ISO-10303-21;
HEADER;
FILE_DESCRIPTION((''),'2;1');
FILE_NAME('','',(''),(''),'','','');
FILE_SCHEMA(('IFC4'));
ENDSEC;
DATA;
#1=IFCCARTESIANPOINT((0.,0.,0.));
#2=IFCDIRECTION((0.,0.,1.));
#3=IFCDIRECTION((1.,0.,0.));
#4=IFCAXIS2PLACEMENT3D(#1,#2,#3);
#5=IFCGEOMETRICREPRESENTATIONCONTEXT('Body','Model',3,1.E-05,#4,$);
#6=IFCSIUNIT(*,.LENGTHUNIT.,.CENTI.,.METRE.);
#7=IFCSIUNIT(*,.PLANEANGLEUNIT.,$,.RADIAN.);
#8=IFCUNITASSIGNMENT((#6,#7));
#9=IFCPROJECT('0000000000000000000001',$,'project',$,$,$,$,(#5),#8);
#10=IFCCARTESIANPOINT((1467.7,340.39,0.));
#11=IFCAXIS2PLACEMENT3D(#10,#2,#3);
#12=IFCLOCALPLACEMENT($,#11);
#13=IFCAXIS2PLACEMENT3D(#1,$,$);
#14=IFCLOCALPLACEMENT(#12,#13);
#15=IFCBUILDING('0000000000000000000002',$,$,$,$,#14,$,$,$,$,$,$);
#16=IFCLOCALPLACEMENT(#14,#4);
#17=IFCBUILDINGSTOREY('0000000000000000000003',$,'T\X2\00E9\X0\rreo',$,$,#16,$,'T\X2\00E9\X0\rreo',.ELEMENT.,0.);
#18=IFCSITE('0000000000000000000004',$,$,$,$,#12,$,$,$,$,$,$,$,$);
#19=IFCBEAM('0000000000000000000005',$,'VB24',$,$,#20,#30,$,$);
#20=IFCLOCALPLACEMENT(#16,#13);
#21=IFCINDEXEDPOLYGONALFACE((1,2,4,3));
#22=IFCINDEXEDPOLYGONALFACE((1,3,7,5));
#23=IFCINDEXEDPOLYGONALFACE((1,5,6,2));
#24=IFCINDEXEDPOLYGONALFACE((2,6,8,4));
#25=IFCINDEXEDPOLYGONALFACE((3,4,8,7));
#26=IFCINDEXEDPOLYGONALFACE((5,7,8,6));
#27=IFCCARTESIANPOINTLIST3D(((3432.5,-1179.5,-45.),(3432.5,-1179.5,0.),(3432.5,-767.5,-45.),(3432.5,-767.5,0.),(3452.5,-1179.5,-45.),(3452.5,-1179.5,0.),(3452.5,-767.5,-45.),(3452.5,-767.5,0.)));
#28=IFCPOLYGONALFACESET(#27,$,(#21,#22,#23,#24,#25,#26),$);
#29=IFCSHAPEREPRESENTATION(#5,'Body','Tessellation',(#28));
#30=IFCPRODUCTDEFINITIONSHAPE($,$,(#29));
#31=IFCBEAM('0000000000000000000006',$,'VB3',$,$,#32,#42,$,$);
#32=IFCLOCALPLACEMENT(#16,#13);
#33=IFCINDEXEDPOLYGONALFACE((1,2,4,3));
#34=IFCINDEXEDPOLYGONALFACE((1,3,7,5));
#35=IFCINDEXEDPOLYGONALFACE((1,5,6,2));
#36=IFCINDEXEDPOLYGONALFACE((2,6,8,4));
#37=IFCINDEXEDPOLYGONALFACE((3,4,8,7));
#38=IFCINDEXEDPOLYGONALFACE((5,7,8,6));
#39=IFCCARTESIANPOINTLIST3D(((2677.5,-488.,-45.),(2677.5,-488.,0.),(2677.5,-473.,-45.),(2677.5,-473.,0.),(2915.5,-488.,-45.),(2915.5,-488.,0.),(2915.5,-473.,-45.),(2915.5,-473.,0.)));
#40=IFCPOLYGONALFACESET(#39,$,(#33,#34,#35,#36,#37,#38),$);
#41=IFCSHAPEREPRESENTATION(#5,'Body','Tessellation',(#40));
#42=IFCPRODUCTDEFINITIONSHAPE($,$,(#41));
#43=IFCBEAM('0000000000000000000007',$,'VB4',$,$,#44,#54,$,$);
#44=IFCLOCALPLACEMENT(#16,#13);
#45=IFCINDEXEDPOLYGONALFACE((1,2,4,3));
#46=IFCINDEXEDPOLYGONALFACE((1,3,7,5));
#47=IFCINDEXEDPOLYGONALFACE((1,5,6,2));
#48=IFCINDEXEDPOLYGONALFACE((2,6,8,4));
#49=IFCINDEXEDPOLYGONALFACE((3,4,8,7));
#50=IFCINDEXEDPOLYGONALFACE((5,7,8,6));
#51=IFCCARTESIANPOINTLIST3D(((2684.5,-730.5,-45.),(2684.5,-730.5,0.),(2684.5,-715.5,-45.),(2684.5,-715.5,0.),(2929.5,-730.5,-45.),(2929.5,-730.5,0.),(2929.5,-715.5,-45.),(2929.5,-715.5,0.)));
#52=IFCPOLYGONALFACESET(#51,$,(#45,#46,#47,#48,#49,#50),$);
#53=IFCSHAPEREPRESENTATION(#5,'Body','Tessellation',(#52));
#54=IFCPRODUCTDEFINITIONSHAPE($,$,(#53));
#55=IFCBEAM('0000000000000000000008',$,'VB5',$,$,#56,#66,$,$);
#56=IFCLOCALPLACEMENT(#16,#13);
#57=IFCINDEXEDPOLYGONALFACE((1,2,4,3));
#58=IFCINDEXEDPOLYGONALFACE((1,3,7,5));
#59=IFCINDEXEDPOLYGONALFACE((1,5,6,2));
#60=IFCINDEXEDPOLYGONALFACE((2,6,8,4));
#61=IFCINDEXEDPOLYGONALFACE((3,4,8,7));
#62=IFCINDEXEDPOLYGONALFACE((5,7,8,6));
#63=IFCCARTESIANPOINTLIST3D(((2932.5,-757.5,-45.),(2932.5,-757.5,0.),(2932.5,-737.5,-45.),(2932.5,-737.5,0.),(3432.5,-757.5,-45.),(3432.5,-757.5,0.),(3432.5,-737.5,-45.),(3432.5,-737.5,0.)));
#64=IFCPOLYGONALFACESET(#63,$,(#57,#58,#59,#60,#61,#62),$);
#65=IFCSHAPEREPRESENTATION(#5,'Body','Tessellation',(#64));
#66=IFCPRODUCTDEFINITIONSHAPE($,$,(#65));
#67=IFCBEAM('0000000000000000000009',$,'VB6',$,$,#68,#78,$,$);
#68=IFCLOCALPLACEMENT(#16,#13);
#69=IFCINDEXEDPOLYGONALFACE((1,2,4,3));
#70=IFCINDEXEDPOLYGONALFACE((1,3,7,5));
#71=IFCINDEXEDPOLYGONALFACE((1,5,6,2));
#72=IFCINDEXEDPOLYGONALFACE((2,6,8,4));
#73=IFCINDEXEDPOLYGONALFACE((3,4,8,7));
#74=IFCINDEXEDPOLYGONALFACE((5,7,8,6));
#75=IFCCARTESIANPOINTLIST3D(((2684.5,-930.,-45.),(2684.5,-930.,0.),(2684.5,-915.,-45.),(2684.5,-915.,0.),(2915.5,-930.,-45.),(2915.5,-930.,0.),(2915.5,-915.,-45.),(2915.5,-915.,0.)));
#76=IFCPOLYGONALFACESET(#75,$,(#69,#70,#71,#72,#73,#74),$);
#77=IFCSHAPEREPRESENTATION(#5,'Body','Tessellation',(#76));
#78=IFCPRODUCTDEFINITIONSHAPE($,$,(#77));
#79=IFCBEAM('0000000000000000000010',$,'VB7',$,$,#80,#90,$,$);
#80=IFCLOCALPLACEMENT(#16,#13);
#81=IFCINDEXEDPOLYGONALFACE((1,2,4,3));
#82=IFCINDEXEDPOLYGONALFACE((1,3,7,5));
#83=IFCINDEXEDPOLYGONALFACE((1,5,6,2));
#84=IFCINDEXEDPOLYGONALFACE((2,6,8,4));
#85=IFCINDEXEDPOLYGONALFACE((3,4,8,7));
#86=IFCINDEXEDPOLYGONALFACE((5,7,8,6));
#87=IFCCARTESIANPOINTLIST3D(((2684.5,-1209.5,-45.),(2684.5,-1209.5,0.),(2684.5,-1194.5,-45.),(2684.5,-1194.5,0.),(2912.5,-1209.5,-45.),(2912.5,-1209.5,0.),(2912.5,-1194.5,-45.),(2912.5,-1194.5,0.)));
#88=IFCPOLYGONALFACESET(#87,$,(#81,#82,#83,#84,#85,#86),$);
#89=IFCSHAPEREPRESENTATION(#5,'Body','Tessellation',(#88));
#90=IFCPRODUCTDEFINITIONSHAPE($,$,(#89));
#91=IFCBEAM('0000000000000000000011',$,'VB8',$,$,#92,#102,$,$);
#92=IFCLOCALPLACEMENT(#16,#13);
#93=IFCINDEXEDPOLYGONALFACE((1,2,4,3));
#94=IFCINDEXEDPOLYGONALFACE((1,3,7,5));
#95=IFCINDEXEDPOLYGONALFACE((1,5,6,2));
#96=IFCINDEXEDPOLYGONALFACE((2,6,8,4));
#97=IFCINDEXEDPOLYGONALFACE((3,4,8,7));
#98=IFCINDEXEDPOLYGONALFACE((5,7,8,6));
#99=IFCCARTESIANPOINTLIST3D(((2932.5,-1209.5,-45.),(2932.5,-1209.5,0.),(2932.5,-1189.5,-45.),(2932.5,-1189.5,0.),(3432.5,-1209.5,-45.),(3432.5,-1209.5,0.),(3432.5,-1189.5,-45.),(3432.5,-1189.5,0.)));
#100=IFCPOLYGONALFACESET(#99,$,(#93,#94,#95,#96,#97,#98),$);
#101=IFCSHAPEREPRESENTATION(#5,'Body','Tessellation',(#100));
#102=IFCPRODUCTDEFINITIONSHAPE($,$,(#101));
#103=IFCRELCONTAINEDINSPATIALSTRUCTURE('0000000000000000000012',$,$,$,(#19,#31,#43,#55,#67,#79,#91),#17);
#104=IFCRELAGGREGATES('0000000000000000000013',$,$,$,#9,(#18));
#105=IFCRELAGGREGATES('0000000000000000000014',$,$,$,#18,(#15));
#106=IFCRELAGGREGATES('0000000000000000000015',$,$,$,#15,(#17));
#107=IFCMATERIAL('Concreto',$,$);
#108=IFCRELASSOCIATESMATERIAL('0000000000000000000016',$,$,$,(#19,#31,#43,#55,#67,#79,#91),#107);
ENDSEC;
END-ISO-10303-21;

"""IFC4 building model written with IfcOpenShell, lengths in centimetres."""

from ifc_helpers import new_model, si_unit, frame, origin, origin_with_axes, origin_2d_with_axis, place, context, project, spatial, rectangle, extrude, material, element, save


model = new_model("IFC4")

# Units and contexts
model_context = context("Model", 3, precision=1e-05, world=origin_with_axes(), identifier="Body")
ifc_project = project(units=[si_unit("LENGTHUNIT", "METRE", prefix="CENTI"), si_unit("PLANEANGLEUNIT", "RADIAN")], contexts=[model_context])

# Site, building, storey
site_placement = place(None, frame((1467.7, 340.39, 0.0), z_axis=(0.0, 0.0, 1.0), x_axis=(1.0, 0.0, 0.0)))
site = spatial("IfcSite", under=ifc_project, at=site_placement)
building_placement = place(site_placement, origin())
building = spatial("IfcBuilding", under=site, at=building_placement)
storey_placement = place(building_placement, origin_with_axes())
storey = spatial("IfcBuildingStorey", under=building, at=storey_placement, Name="Térreo", LongName="Térreo", CompositionType="ELEMENT", Elevation=0.0)

# Shared definitions
ifc_material = material(Name="Concreto")

# Beams
beam_1_placement = place(storey_placement, frame((3442.5, -973.5, 0.0), z_axis=(0.0, 0.0, 1.0), x_axis=(1.0, 0.0, 0.0)))
element("IfcBeam", 1, at=beam_1_placement, inside=storey, material=ifc_material, Name="VB24", context=model_context, shape_type="SolidModel", body=[
    extrude(rectangle(XDim=20.0, YDim=45.0, at=origin_2d_with_axis()), frame((0.0, -206.0, -22.5), z_axis=(0.0, 1.0, 0.0), x_axis=(1.0, 0.0, 0.0)), (0.0, 0.0, 1.0), 412.0),
])
beam_2_placement = place(storey_placement, frame((2796.5, -480.5, 0.0), z_axis=(0.0, 0.0, 1.0), x_axis=(1.0, 0.0, 0.0)))
element("IfcBeam", 2, at=beam_2_placement, inside=storey, material=ifc_material, Name="VB3", context=model_context, shape_type="SolidModel", body=[
    extrude(rectangle(XDim=15.0, YDim=45.0, at=origin_2d_with_axis()), frame((-119.0, 0.0, -22.5), z_axis=(1.0, 0.0, 0.0), x_axis=(0.0, 1.0, 0.0)), (0.0, 0.0, 1.0), 238.0),
])
beam_3_placement = place(storey_placement, frame((2807.0, -723.0, 0.0), z_axis=(0.0, 0.0, 1.0), x_axis=(1.0, 0.0, 0.0)))
element("IfcBeam", 3, at=beam_3_placement, inside=storey, material=ifc_material, Name="VB4", context=model_context, shape_type="SolidModel", body=[
    extrude(rectangle(XDim=15.0, YDim=45.0, at=origin_2d_with_axis()), frame((-122.5, 0.0, -22.5), z_axis=(1.0, 0.0, 0.0), x_axis=(0.0, 1.0, 0.0)), (0.0, 0.0, 1.0), 245.0),
])
beam_4_placement = place(storey_placement, frame((3182.5, -747.5, 0.0), z_axis=(0.0, 0.0, 1.0), x_axis=(1.0, 0.0, 0.0)))
element("IfcBeam", 4, at=beam_4_placement, inside=storey, material=ifc_material, Name="VB5", context=model_context, shape_type="SolidModel", body=[
    extrude(rectangle(XDim=20.0, YDim=45.0, at=origin_2d_with_axis()), frame((-250.0, 0.0, -22.5), z_axis=(1.0, 0.0, 0.0), x_axis=(0.0, 1.0, 0.0)), (0.0, 0.0, 1.0), 500.0),
])
beam_5_placement = place(storey_placement, frame((2800.0, -922.5, 0.0), z_axis=(0.0, 0.0, 1.0), x_axis=(1.0, 0.0, 0.0)))
element("IfcBeam", 5, at=beam_5_placement, inside=storey, material=ifc_material, Name="VB6", context=model_context, shape_type="SolidModel", body=[
    extrude(rectangle(XDim=15.0, YDim=45.0, at=origin_2d_with_axis()), frame((-115.5, 0.0, -22.5), z_axis=(1.0, 0.0, 0.0), x_axis=(0.0, 1.0, 0.0)), (0.0, 0.0, 1.0), 231.0),
])
beam_6_placement = place(storey_placement, frame((2798.5, -1202.0, 0.0), z_axis=(0.0, 0.0, 1.0), x_axis=(1.0, 0.0, 0.0)))
element("IfcBeam", 6, at=beam_6_placement, inside=storey, material=ifc_material, Name="VB7", context=model_context, shape_type="SolidModel", body=[
    extrude(rectangle(XDim=15.0, YDim=45.0, at=origin_2d_with_axis()), frame((-114.0, 0.0, -22.5), z_axis=(1.0, 0.0, 0.0), x_axis=(0.0, 1.0, 0.0)), (0.0, 0.0, 1.0), 228.0),
])
beam_7_placement = place(storey_placement, frame((3182.5, -1199.5, 0.0), z_axis=(0.0, 0.0, 1.0), x_axis=(1.0, 0.0, 0.0)))
element("IfcBeam", 7, at=beam_7_placement, inside=storey, material=ifc_material, Name="VB8", context=model_context, shape_type="SolidModel", body=[
    extrude(rectangle(XDim=20.0, YDim=45.0, at=origin_2d_with_axis()), frame((-250.0, 0.0, -22.5), z_axis=(1.0, 0.0, 0.0), x_axis=(0.0, 1.0, 0.0)), (0.0, 0.0, 1.0), 500.0),
])

save(model, "model.ifc")
